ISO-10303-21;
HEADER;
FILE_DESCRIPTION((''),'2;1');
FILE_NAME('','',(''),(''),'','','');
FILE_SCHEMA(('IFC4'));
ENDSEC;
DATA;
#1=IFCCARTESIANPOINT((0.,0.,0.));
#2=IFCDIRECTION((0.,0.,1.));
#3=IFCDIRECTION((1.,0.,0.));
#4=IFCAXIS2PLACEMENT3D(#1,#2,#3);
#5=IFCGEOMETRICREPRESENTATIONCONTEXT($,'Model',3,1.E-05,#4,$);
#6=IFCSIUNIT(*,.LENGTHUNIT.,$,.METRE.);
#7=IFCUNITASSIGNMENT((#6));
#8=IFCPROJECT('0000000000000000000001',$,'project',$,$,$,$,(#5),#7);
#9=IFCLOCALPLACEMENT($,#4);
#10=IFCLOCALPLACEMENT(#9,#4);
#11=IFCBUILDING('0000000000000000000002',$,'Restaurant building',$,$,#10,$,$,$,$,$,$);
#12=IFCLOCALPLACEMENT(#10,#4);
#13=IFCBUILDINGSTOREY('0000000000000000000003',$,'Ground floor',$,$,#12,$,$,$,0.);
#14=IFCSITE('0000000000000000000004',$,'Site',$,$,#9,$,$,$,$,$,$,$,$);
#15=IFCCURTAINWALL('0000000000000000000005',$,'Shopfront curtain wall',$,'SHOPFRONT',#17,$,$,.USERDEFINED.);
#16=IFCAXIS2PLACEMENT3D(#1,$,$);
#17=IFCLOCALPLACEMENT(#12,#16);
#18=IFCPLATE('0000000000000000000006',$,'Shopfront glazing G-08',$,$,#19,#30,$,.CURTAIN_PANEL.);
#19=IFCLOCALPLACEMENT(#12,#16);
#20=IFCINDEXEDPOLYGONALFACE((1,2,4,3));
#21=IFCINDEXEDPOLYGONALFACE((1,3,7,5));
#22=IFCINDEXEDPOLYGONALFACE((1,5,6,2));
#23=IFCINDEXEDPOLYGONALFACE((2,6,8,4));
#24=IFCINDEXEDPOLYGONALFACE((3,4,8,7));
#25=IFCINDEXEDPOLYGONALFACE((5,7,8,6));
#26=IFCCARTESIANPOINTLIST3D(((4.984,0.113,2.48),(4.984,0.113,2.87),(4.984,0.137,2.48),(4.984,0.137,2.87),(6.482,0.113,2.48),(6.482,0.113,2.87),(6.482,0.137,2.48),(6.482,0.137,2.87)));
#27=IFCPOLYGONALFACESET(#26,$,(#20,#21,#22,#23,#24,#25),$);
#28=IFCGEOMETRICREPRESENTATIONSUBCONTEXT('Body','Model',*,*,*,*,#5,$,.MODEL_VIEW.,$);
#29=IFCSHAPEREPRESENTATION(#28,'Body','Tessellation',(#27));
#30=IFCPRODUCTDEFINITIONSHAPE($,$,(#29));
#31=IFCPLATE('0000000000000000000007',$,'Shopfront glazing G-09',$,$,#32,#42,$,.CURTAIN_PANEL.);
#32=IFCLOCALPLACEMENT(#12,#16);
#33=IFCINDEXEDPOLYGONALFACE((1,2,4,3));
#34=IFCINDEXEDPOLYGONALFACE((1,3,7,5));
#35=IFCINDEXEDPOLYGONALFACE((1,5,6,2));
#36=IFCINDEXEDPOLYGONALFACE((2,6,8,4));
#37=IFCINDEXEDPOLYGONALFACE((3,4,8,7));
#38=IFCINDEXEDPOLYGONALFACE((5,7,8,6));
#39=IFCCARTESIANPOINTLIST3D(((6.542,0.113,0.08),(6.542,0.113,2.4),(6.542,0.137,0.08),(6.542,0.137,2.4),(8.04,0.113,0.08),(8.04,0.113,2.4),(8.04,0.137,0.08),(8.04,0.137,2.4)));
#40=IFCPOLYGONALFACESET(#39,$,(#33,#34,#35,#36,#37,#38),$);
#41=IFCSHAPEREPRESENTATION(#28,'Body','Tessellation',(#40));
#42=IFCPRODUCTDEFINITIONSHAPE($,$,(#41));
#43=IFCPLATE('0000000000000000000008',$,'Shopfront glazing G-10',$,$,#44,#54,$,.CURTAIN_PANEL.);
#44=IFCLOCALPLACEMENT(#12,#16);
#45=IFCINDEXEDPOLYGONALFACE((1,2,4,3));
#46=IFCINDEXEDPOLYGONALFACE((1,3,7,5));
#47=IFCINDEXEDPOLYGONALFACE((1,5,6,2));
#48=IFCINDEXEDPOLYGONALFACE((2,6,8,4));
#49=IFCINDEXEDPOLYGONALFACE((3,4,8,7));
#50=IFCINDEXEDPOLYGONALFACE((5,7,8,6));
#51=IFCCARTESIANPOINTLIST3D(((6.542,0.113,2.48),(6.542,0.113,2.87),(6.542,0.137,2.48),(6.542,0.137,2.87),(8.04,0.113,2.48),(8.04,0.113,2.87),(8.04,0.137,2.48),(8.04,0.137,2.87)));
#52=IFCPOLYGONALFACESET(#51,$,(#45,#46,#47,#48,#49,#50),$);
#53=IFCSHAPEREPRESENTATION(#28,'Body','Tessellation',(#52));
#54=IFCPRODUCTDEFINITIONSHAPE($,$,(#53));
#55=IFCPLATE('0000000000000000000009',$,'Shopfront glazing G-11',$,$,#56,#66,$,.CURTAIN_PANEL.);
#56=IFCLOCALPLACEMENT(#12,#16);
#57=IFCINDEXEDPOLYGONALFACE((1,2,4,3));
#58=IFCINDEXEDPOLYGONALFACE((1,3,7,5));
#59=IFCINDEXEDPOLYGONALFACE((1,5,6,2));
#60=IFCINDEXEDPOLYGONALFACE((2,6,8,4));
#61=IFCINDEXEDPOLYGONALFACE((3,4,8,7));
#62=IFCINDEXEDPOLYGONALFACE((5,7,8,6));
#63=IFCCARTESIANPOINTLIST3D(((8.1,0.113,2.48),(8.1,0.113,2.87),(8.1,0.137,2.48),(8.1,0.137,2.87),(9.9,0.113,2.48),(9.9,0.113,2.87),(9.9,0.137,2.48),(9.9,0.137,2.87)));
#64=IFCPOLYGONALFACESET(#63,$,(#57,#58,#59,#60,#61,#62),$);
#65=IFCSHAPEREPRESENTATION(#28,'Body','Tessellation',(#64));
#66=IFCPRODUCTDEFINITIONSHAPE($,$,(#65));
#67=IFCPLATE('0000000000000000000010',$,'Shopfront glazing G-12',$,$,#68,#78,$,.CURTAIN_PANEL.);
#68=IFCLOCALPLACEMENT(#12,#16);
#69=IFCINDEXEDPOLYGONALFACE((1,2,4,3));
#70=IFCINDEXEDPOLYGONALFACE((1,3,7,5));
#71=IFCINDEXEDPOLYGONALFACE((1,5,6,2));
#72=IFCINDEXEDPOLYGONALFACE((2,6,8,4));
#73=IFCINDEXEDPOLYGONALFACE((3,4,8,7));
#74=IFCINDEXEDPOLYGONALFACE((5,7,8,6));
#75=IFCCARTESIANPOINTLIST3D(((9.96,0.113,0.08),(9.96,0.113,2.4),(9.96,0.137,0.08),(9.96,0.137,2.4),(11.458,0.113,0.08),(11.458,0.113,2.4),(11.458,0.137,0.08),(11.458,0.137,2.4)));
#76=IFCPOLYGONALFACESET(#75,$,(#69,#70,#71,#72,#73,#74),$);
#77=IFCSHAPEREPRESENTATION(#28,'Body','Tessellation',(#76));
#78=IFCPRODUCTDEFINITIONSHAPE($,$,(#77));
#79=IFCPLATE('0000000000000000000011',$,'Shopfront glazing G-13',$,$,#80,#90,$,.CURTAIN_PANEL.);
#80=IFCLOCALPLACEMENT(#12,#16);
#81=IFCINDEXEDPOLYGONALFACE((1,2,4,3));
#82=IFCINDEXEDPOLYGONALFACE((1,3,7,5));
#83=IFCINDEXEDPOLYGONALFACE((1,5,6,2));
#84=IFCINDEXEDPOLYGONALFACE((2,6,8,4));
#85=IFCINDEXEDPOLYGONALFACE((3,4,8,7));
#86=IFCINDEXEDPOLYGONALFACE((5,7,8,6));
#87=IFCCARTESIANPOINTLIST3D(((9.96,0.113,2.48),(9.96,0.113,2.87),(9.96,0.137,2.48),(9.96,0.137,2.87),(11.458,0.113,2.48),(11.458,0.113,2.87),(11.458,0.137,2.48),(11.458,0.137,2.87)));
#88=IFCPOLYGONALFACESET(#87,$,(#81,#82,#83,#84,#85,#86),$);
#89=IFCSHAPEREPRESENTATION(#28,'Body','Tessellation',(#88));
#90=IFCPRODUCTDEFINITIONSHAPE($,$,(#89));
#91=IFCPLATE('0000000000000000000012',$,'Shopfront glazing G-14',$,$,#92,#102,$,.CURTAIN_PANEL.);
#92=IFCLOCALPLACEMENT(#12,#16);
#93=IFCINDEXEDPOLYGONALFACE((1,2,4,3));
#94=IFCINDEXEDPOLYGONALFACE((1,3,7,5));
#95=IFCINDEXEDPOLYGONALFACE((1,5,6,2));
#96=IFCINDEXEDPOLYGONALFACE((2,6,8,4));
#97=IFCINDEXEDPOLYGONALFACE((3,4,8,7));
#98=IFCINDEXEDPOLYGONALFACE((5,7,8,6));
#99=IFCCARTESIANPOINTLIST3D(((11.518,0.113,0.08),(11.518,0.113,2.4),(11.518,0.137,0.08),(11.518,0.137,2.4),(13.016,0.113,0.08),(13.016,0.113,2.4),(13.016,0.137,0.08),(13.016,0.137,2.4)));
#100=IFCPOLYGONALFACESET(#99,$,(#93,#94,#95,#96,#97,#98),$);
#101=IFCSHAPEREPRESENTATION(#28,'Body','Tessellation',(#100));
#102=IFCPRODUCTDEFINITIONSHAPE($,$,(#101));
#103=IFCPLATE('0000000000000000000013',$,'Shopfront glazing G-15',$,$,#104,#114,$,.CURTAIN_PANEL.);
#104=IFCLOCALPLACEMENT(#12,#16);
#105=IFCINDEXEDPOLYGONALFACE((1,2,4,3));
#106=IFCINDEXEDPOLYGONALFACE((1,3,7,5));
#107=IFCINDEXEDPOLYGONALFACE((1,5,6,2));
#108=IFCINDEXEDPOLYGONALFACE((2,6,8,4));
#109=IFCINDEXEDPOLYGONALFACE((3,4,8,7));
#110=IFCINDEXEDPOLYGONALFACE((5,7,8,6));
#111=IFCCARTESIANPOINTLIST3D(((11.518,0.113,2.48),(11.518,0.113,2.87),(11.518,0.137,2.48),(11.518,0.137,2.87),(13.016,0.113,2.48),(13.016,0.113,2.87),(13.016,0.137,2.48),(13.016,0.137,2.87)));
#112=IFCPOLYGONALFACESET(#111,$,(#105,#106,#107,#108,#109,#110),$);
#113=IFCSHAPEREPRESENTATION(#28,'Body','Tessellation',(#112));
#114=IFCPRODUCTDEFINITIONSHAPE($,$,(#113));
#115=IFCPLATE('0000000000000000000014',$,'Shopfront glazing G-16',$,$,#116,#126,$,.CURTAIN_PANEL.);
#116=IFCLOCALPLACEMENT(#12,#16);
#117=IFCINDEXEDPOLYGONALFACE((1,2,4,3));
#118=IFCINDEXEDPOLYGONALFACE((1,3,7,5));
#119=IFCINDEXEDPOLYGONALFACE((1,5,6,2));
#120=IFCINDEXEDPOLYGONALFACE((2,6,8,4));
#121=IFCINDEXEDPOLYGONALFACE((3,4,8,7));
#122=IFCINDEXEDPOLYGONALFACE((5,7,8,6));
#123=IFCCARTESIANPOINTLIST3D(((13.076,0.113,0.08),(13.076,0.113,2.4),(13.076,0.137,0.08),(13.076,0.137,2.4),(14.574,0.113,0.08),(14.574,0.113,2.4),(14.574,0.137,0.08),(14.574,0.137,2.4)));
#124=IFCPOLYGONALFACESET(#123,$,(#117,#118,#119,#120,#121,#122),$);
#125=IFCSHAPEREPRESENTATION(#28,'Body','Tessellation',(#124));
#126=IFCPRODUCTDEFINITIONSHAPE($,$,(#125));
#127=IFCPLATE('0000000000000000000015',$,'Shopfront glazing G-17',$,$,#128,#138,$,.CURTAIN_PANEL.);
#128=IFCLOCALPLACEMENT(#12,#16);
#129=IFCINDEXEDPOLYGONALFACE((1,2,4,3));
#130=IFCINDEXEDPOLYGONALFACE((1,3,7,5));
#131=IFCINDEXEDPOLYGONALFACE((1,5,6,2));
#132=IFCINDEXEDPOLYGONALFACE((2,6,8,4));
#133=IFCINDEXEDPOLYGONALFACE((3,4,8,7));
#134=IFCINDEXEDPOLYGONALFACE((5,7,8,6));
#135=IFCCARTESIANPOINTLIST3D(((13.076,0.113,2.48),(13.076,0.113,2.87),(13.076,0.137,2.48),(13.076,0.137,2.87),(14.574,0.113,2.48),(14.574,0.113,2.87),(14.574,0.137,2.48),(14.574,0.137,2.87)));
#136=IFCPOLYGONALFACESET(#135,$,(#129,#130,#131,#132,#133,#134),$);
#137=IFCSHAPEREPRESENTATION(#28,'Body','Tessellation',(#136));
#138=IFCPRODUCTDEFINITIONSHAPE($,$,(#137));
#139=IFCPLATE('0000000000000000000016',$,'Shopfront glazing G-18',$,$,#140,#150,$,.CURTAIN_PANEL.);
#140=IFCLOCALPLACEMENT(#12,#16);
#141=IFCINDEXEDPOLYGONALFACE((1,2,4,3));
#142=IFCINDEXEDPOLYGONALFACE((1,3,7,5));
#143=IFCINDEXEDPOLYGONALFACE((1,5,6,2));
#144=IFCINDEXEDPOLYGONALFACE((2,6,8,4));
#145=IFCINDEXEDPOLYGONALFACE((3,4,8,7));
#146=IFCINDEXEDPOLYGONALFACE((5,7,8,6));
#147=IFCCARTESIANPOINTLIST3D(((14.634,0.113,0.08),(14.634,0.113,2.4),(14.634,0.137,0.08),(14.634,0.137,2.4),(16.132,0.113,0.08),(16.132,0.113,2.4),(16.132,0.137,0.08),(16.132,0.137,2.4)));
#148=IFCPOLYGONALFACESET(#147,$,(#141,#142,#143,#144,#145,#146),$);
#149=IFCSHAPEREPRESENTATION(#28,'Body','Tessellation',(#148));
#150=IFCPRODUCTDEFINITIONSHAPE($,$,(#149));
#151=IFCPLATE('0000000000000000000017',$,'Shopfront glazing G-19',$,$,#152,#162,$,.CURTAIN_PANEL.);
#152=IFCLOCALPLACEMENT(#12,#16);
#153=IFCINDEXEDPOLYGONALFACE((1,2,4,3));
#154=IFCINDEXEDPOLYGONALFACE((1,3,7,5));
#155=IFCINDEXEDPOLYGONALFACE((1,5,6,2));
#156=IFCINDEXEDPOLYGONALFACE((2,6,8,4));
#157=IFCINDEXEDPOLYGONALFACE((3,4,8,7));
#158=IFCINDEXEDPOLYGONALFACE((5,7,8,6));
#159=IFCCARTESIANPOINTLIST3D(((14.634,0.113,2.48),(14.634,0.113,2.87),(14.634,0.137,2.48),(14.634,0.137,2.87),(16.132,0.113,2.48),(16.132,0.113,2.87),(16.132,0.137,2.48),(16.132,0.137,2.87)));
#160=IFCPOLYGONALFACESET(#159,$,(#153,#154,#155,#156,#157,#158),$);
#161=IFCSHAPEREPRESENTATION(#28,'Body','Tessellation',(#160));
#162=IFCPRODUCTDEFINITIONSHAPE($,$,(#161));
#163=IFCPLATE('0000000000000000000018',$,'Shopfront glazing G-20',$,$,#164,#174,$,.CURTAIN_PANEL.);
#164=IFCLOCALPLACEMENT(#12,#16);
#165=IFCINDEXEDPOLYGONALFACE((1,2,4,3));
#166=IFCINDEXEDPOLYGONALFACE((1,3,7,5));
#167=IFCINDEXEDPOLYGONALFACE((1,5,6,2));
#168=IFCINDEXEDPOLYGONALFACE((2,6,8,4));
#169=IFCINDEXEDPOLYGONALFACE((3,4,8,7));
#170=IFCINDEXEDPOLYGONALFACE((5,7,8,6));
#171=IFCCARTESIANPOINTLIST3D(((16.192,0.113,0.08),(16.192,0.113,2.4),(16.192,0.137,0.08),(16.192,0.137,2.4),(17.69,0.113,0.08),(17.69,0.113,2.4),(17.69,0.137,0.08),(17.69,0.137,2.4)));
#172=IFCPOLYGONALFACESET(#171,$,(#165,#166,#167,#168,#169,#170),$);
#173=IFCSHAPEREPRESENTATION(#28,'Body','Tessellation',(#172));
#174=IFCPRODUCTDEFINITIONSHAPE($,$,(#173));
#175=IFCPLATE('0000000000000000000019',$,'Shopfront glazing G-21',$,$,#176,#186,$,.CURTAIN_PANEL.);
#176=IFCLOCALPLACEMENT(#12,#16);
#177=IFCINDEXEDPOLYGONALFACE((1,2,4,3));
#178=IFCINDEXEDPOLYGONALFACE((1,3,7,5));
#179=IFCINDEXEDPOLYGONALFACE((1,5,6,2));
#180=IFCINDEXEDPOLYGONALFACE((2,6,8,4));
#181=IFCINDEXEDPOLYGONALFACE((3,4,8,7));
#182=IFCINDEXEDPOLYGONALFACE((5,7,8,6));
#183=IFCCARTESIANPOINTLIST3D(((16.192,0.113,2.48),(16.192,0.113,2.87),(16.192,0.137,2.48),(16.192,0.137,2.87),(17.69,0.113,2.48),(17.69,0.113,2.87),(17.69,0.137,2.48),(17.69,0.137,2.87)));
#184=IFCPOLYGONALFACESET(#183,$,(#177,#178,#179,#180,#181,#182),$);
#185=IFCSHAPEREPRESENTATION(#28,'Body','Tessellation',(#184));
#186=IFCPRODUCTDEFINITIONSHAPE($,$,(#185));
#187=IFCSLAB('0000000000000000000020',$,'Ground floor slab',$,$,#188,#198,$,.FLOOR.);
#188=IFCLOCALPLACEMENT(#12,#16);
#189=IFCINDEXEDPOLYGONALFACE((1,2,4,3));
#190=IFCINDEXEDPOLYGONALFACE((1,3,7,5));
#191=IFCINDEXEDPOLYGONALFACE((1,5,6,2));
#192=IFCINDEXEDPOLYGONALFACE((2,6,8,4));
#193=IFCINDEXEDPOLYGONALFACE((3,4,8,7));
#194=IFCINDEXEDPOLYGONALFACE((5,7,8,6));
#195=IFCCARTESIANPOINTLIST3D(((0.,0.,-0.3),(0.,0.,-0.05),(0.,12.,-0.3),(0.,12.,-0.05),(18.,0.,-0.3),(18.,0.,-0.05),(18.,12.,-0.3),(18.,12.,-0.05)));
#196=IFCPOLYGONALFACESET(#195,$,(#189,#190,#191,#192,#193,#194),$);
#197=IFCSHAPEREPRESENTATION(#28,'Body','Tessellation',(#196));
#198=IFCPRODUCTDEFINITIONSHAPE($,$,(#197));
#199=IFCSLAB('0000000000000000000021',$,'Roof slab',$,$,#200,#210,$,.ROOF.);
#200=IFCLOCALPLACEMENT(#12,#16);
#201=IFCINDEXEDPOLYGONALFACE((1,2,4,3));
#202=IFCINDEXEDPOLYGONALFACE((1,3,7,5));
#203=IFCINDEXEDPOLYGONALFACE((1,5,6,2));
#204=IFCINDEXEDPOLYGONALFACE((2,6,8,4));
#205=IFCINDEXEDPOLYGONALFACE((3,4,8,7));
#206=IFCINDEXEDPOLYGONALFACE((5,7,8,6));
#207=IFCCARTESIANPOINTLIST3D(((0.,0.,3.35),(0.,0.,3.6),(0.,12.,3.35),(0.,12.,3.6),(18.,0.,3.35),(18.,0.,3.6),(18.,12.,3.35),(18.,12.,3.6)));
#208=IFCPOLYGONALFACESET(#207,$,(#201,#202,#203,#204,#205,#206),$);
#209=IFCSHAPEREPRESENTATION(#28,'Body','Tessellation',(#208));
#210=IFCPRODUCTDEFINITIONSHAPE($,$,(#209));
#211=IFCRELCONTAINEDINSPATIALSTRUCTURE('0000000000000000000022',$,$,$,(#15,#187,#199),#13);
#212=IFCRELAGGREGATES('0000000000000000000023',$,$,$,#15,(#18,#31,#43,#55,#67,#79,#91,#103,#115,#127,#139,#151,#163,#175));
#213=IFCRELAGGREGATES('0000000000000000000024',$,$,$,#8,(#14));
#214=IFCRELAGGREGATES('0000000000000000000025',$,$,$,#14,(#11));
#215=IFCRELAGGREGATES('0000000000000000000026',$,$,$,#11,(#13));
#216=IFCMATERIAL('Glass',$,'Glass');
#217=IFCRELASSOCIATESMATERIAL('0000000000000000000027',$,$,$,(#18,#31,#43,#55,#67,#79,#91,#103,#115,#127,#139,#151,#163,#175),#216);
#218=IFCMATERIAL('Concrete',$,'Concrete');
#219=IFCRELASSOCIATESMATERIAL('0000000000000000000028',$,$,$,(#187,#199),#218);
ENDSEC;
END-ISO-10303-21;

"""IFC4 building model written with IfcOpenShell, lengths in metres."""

from ifc_helpers import new_model, si_unit, frame, origin, origin_with_axes, origin_2d, place, context, subcontext, project, spatial, rectangle, extrude, material, element, aggregate, save


model = new_model("IFC4")

# Units and contexts
model_context = context("Model", 3, precision=1e-05, world=origin_with_axes())
body_context = subcontext(model_context, "Body", "Model", "MODEL_VIEW")
ifc_project = project(units=[si_unit("LENGTHUNIT", "METRE")], contexts=[model_context])

# Site, building, storey
site_placement = place(None, origin_with_axes())
site = spatial("IfcSite", under=ifc_project, at=site_placement, Name="Site")
building_placement = place(site_placement, origin_with_axes())
building = spatial("IfcBuilding", under=site, at=building_placement, Name="Restaurant building")
storey_placement = place(building_placement, origin_with_axes())
storey = spatial("IfcBuildingStorey", under=building, at=storey_placement, Name="Ground floor", Elevation=0.0)

# Curtain wall, plates
curtain_wall_placement = place(storey_placement, origin())
curtain_wall = element("IfcCurtainWall", 1, at=curtain_wall_placement, inside=storey, Name="Shopfront curtain wall", ObjectType="SHOPFRONT", PredefinedType="USERDEFINED")
ifc_material_1 = material(Name="Glass", Category="Glass")
plate_1_placement = place(curtain_wall_placement, origin_with_axes())
plate_1 = element("IfcPlate", 2, at=plate_1_placement, material=ifc_material_1, Name="Shopfront glazing G-08", PredefinedType="CURTAIN_PANEL", context=body_context, shape_type="SweptSolid", body=[
    extrude(rectangle(XDim=1.498, YDim=0.024, at=origin_2d()), frame((5.733, 0.125, 2.48)), (0.0, 0.0, 1.0), 0.39),
])
plate_2_placement = place(curtain_wall_placement, origin_with_axes())
plate_2 = element("IfcPlate", 3, at=plate_2_placement, material=ifc_material_1, Name="Shopfront glazing G-09", PredefinedType="CURTAIN_PANEL", context=body_context, shape_type="SweptSolid", body=[
    extrude(rectangle(XDim=1.498, YDim=0.024, at=origin_2d()), frame((7.291, 0.125, 0.08)), (0.0, 0.0, 1.0), 2.32),
])
plate_3_placement = place(curtain_wall_placement, origin_with_axes())
plate_3 = element("IfcPlate", 4, at=plate_3_placement, material=ifc_material_1, Name="Shopfront glazing G-10", PredefinedType="CURTAIN_PANEL", context=body_context, shape_type="SweptSolid", body=[
    extrude(rectangle(XDim=1.498, YDim=0.024, at=origin_2d()), frame((7.291, 0.125, 2.48)), (0.0, 0.0, 1.0), 0.39),
])
plate_4_placement = place(curtain_wall_placement, origin_with_axes())
plate_4 = element("IfcPlate", 5, at=plate_4_placement, material=ifc_material_1, Name="Shopfront glazing G-11", PredefinedType="CURTAIN_PANEL", context=body_context, shape_type="SweptSolid", body=[
    extrude(rectangle(XDim=1.8, YDim=0.024, at=origin_2d()), frame((9.0, 0.125, 2.48)), (0.0, 0.0, 1.0), 0.39),
])
plate_5_placement = place(curtain_wall_placement, origin_with_axes())
plate_5 = element("IfcPlate", 6, at=plate_5_placement, material=ifc_material_1, Name="Shopfront glazing G-12", PredefinedType="CURTAIN_PANEL", context=body_context, shape_type="SweptSolid", body=[
    extrude(rectangle(XDim=1.498, YDim=0.024, at=origin_2d()), frame((10.709, 0.125, 0.08)), (0.0, 0.0, 1.0), 2.32),
])
plate_6_placement = place(curtain_wall_placement, origin_with_axes())
plate_6 = element("IfcPlate", 7, at=plate_6_placement, material=ifc_material_1, Name="Shopfront glazing G-13", PredefinedType="CURTAIN_PANEL", context=body_context, shape_type="SweptSolid", body=[
    extrude(rectangle(XDim=1.498, YDim=0.024, at=origin_2d()), frame((10.709, 0.125, 2.48)), (0.0, 0.0, 1.0), 0.39),
])
plate_7_placement = place(curtain_wall_placement, origin_with_axes())
plate_7 = element("IfcPlate", 8, at=plate_7_placement, material=ifc_material_1, Name="Shopfront glazing G-14", PredefinedType="CURTAIN_PANEL", context=body_context, shape_type="SweptSolid", body=[
    extrude(rectangle(XDim=1.498, YDim=0.024, at=origin_2d()), frame((12.267, 0.125, 0.08)), (0.0, 0.0, 1.0), 2.32),
])
plate_8_placement = place(curtain_wall_placement, origin_with_axes())
plate_8 = element("IfcPlate", 9, at=plate_8_placement, material=ifc_material_1, Name="Shopfront glazing G-15", PredefinedType="CURTAIN_PANEL", context=body_context, shape_type="SweptSolid", body=[
    extrude(rectangle(XDim=1.498, YDim=0.024, at=origin_2d()), frame((12.267, 0.125, 2.48)), (0.0, 0.0, 1.0), 0.39),
])
plate_9_placement = place(curtain_wall_placement, origin_with_axes())
plate_9 = element("IfcPlate", 10, at=plate_9_placement, material=ifc_material_1, Name="Shopfront glazing G-16", PredefinedType="CURTAIN_PANEL", context=body_context, shape_type="SweptSolid", body=[
    extrude(rectangle(XDim=1.498, YDim=0.024, at=origin_2d()), frame((13.825, 0.125, 0.08)), (0.0, 0.0, 1.0), 2.32),
])
plate_10_placement = place(curtain_wall_placement, origin_with_axes())
plate_10 = element("IfcPlate", 11, at=plate_10_placement, material=ifc_material_1, Name="Shopfront glazing G-17", PredefinedType="CURTAIN_PANEL", context=body_context, shape_type="SweptSolid", body=[
    extrude(rectangle(XDim=1.498, YDim=0.024, at=origin_2d()), frame((13.825, 0.125, 2.48)), (0.0, 0.0, 1.0), 0.39),
])
plate_11_placement = place(curtain_wall_placement, origin_with_axes())
plate_11 = element("IfcPlate", 12, at=plate_11_placement, material=ifc_material_1, Name="Shopfront glazing G-18", PredefinedType="CURTAIN_PANEL", context=body_context, shape_type="SweptSolid", body=[
    extrude(rectangle(XDim=1.498, YDim=0.024, at=origin_2d()), frame((15.383, 0.125, 0.08)), (0.0, 0.0, 1.0), 2.32),
])
plate_12_placement = place(curtain_wall_placement, origin_with_axes())
plate_12 = element("IfcPlate", 13, at=plate_12_placement, material=ifc_material_1, Name="Shopfront glazing G-19", PredefinedType="CURTAIN_PANEL", context=body_context, shape_type="SweptSolid", body=[
    extrude(rectangle(XDim=1.498, YDim=0.024, at=origin_2d()), frame((15.383, 0.125, 2.48)), (0.0, 0.0, 1.0), 0.39),
])
plate_13_placement = place(curtain_wall_placement, origin_with_axes())
plate_13 = element("IfcPlate", 14, at=plate_13_placement, material=ifc_material_1, Name="Shopfront glazing G-20", PredefinedType="CURTAIN_PANEL", context=body_context, shape_type="SweptSolid", body=[
    extrude(rectangle(XDim=1.498, YDim=0.024, at=origin_2d()), frame((16.941, 0.125, 0.08)), (0.0, 0.0, 1.0), 2.32),
])
plate_14_placement = place(curtain_wall_placement, origin_with_axes())
plate_14 = element("IfcPlate", 15, at=plate_14_placement, material=ifc_material_1, Name="Shopfront glazing G-21", PredefinedType="CURTAIN_PANEL", context=body_context, shape_type="SweptSolid", body=[
    extrude(rectangle(XDim=1.498, YDim=0.024, at=origin_2d()), frame((16.941, 0.125, 2.48)), (0.0, 0.0, 1.0), 0.39),
])
aggregate(curtain_wall, [plate_1, plate_2, plate_3, plate_4, plate_5, plate_6, plate_7, plate_8, plate_9, plate_10, plate_11, plate_12, plate_13, plate_14])

# Slabs
ifc_material_2 = material(Name="Concrete", Category="Concrete")
slab_1_placement = place(storey_placement, origin())
element("IfcSlab", 16, at=slab_1_placement, inside=storey, material=ifc_material_2, Name="Ground floor slab", PredefinedType="FLOOR", context=body_context, shape_type="SweptSolid", body=[
    extrude(rectangle(XDim=18.0, YDim=12.0, at=origin_2d()), frame((9.0, 6.0, -0.3)), (0.0, 0.0, 1.0), 0.25),
])
slab_2_placement = place(storey_placement, origin())
element("IfcSlab", 17, at=slab_2_placement, inside=storey, material=ifc_material_2, Name="Roof slab", PredefinedType="ROOF", context=body_context, shape_type="SweptSolid", body=[
    extrude(rectangle(XDim=18.0, YDim=12.0, at=origin_2d()), frame((9.0, 6.0, 3.35)), (0.0, 0.0, 1.0), 0.25),
])

save(model, "model.ifc")
